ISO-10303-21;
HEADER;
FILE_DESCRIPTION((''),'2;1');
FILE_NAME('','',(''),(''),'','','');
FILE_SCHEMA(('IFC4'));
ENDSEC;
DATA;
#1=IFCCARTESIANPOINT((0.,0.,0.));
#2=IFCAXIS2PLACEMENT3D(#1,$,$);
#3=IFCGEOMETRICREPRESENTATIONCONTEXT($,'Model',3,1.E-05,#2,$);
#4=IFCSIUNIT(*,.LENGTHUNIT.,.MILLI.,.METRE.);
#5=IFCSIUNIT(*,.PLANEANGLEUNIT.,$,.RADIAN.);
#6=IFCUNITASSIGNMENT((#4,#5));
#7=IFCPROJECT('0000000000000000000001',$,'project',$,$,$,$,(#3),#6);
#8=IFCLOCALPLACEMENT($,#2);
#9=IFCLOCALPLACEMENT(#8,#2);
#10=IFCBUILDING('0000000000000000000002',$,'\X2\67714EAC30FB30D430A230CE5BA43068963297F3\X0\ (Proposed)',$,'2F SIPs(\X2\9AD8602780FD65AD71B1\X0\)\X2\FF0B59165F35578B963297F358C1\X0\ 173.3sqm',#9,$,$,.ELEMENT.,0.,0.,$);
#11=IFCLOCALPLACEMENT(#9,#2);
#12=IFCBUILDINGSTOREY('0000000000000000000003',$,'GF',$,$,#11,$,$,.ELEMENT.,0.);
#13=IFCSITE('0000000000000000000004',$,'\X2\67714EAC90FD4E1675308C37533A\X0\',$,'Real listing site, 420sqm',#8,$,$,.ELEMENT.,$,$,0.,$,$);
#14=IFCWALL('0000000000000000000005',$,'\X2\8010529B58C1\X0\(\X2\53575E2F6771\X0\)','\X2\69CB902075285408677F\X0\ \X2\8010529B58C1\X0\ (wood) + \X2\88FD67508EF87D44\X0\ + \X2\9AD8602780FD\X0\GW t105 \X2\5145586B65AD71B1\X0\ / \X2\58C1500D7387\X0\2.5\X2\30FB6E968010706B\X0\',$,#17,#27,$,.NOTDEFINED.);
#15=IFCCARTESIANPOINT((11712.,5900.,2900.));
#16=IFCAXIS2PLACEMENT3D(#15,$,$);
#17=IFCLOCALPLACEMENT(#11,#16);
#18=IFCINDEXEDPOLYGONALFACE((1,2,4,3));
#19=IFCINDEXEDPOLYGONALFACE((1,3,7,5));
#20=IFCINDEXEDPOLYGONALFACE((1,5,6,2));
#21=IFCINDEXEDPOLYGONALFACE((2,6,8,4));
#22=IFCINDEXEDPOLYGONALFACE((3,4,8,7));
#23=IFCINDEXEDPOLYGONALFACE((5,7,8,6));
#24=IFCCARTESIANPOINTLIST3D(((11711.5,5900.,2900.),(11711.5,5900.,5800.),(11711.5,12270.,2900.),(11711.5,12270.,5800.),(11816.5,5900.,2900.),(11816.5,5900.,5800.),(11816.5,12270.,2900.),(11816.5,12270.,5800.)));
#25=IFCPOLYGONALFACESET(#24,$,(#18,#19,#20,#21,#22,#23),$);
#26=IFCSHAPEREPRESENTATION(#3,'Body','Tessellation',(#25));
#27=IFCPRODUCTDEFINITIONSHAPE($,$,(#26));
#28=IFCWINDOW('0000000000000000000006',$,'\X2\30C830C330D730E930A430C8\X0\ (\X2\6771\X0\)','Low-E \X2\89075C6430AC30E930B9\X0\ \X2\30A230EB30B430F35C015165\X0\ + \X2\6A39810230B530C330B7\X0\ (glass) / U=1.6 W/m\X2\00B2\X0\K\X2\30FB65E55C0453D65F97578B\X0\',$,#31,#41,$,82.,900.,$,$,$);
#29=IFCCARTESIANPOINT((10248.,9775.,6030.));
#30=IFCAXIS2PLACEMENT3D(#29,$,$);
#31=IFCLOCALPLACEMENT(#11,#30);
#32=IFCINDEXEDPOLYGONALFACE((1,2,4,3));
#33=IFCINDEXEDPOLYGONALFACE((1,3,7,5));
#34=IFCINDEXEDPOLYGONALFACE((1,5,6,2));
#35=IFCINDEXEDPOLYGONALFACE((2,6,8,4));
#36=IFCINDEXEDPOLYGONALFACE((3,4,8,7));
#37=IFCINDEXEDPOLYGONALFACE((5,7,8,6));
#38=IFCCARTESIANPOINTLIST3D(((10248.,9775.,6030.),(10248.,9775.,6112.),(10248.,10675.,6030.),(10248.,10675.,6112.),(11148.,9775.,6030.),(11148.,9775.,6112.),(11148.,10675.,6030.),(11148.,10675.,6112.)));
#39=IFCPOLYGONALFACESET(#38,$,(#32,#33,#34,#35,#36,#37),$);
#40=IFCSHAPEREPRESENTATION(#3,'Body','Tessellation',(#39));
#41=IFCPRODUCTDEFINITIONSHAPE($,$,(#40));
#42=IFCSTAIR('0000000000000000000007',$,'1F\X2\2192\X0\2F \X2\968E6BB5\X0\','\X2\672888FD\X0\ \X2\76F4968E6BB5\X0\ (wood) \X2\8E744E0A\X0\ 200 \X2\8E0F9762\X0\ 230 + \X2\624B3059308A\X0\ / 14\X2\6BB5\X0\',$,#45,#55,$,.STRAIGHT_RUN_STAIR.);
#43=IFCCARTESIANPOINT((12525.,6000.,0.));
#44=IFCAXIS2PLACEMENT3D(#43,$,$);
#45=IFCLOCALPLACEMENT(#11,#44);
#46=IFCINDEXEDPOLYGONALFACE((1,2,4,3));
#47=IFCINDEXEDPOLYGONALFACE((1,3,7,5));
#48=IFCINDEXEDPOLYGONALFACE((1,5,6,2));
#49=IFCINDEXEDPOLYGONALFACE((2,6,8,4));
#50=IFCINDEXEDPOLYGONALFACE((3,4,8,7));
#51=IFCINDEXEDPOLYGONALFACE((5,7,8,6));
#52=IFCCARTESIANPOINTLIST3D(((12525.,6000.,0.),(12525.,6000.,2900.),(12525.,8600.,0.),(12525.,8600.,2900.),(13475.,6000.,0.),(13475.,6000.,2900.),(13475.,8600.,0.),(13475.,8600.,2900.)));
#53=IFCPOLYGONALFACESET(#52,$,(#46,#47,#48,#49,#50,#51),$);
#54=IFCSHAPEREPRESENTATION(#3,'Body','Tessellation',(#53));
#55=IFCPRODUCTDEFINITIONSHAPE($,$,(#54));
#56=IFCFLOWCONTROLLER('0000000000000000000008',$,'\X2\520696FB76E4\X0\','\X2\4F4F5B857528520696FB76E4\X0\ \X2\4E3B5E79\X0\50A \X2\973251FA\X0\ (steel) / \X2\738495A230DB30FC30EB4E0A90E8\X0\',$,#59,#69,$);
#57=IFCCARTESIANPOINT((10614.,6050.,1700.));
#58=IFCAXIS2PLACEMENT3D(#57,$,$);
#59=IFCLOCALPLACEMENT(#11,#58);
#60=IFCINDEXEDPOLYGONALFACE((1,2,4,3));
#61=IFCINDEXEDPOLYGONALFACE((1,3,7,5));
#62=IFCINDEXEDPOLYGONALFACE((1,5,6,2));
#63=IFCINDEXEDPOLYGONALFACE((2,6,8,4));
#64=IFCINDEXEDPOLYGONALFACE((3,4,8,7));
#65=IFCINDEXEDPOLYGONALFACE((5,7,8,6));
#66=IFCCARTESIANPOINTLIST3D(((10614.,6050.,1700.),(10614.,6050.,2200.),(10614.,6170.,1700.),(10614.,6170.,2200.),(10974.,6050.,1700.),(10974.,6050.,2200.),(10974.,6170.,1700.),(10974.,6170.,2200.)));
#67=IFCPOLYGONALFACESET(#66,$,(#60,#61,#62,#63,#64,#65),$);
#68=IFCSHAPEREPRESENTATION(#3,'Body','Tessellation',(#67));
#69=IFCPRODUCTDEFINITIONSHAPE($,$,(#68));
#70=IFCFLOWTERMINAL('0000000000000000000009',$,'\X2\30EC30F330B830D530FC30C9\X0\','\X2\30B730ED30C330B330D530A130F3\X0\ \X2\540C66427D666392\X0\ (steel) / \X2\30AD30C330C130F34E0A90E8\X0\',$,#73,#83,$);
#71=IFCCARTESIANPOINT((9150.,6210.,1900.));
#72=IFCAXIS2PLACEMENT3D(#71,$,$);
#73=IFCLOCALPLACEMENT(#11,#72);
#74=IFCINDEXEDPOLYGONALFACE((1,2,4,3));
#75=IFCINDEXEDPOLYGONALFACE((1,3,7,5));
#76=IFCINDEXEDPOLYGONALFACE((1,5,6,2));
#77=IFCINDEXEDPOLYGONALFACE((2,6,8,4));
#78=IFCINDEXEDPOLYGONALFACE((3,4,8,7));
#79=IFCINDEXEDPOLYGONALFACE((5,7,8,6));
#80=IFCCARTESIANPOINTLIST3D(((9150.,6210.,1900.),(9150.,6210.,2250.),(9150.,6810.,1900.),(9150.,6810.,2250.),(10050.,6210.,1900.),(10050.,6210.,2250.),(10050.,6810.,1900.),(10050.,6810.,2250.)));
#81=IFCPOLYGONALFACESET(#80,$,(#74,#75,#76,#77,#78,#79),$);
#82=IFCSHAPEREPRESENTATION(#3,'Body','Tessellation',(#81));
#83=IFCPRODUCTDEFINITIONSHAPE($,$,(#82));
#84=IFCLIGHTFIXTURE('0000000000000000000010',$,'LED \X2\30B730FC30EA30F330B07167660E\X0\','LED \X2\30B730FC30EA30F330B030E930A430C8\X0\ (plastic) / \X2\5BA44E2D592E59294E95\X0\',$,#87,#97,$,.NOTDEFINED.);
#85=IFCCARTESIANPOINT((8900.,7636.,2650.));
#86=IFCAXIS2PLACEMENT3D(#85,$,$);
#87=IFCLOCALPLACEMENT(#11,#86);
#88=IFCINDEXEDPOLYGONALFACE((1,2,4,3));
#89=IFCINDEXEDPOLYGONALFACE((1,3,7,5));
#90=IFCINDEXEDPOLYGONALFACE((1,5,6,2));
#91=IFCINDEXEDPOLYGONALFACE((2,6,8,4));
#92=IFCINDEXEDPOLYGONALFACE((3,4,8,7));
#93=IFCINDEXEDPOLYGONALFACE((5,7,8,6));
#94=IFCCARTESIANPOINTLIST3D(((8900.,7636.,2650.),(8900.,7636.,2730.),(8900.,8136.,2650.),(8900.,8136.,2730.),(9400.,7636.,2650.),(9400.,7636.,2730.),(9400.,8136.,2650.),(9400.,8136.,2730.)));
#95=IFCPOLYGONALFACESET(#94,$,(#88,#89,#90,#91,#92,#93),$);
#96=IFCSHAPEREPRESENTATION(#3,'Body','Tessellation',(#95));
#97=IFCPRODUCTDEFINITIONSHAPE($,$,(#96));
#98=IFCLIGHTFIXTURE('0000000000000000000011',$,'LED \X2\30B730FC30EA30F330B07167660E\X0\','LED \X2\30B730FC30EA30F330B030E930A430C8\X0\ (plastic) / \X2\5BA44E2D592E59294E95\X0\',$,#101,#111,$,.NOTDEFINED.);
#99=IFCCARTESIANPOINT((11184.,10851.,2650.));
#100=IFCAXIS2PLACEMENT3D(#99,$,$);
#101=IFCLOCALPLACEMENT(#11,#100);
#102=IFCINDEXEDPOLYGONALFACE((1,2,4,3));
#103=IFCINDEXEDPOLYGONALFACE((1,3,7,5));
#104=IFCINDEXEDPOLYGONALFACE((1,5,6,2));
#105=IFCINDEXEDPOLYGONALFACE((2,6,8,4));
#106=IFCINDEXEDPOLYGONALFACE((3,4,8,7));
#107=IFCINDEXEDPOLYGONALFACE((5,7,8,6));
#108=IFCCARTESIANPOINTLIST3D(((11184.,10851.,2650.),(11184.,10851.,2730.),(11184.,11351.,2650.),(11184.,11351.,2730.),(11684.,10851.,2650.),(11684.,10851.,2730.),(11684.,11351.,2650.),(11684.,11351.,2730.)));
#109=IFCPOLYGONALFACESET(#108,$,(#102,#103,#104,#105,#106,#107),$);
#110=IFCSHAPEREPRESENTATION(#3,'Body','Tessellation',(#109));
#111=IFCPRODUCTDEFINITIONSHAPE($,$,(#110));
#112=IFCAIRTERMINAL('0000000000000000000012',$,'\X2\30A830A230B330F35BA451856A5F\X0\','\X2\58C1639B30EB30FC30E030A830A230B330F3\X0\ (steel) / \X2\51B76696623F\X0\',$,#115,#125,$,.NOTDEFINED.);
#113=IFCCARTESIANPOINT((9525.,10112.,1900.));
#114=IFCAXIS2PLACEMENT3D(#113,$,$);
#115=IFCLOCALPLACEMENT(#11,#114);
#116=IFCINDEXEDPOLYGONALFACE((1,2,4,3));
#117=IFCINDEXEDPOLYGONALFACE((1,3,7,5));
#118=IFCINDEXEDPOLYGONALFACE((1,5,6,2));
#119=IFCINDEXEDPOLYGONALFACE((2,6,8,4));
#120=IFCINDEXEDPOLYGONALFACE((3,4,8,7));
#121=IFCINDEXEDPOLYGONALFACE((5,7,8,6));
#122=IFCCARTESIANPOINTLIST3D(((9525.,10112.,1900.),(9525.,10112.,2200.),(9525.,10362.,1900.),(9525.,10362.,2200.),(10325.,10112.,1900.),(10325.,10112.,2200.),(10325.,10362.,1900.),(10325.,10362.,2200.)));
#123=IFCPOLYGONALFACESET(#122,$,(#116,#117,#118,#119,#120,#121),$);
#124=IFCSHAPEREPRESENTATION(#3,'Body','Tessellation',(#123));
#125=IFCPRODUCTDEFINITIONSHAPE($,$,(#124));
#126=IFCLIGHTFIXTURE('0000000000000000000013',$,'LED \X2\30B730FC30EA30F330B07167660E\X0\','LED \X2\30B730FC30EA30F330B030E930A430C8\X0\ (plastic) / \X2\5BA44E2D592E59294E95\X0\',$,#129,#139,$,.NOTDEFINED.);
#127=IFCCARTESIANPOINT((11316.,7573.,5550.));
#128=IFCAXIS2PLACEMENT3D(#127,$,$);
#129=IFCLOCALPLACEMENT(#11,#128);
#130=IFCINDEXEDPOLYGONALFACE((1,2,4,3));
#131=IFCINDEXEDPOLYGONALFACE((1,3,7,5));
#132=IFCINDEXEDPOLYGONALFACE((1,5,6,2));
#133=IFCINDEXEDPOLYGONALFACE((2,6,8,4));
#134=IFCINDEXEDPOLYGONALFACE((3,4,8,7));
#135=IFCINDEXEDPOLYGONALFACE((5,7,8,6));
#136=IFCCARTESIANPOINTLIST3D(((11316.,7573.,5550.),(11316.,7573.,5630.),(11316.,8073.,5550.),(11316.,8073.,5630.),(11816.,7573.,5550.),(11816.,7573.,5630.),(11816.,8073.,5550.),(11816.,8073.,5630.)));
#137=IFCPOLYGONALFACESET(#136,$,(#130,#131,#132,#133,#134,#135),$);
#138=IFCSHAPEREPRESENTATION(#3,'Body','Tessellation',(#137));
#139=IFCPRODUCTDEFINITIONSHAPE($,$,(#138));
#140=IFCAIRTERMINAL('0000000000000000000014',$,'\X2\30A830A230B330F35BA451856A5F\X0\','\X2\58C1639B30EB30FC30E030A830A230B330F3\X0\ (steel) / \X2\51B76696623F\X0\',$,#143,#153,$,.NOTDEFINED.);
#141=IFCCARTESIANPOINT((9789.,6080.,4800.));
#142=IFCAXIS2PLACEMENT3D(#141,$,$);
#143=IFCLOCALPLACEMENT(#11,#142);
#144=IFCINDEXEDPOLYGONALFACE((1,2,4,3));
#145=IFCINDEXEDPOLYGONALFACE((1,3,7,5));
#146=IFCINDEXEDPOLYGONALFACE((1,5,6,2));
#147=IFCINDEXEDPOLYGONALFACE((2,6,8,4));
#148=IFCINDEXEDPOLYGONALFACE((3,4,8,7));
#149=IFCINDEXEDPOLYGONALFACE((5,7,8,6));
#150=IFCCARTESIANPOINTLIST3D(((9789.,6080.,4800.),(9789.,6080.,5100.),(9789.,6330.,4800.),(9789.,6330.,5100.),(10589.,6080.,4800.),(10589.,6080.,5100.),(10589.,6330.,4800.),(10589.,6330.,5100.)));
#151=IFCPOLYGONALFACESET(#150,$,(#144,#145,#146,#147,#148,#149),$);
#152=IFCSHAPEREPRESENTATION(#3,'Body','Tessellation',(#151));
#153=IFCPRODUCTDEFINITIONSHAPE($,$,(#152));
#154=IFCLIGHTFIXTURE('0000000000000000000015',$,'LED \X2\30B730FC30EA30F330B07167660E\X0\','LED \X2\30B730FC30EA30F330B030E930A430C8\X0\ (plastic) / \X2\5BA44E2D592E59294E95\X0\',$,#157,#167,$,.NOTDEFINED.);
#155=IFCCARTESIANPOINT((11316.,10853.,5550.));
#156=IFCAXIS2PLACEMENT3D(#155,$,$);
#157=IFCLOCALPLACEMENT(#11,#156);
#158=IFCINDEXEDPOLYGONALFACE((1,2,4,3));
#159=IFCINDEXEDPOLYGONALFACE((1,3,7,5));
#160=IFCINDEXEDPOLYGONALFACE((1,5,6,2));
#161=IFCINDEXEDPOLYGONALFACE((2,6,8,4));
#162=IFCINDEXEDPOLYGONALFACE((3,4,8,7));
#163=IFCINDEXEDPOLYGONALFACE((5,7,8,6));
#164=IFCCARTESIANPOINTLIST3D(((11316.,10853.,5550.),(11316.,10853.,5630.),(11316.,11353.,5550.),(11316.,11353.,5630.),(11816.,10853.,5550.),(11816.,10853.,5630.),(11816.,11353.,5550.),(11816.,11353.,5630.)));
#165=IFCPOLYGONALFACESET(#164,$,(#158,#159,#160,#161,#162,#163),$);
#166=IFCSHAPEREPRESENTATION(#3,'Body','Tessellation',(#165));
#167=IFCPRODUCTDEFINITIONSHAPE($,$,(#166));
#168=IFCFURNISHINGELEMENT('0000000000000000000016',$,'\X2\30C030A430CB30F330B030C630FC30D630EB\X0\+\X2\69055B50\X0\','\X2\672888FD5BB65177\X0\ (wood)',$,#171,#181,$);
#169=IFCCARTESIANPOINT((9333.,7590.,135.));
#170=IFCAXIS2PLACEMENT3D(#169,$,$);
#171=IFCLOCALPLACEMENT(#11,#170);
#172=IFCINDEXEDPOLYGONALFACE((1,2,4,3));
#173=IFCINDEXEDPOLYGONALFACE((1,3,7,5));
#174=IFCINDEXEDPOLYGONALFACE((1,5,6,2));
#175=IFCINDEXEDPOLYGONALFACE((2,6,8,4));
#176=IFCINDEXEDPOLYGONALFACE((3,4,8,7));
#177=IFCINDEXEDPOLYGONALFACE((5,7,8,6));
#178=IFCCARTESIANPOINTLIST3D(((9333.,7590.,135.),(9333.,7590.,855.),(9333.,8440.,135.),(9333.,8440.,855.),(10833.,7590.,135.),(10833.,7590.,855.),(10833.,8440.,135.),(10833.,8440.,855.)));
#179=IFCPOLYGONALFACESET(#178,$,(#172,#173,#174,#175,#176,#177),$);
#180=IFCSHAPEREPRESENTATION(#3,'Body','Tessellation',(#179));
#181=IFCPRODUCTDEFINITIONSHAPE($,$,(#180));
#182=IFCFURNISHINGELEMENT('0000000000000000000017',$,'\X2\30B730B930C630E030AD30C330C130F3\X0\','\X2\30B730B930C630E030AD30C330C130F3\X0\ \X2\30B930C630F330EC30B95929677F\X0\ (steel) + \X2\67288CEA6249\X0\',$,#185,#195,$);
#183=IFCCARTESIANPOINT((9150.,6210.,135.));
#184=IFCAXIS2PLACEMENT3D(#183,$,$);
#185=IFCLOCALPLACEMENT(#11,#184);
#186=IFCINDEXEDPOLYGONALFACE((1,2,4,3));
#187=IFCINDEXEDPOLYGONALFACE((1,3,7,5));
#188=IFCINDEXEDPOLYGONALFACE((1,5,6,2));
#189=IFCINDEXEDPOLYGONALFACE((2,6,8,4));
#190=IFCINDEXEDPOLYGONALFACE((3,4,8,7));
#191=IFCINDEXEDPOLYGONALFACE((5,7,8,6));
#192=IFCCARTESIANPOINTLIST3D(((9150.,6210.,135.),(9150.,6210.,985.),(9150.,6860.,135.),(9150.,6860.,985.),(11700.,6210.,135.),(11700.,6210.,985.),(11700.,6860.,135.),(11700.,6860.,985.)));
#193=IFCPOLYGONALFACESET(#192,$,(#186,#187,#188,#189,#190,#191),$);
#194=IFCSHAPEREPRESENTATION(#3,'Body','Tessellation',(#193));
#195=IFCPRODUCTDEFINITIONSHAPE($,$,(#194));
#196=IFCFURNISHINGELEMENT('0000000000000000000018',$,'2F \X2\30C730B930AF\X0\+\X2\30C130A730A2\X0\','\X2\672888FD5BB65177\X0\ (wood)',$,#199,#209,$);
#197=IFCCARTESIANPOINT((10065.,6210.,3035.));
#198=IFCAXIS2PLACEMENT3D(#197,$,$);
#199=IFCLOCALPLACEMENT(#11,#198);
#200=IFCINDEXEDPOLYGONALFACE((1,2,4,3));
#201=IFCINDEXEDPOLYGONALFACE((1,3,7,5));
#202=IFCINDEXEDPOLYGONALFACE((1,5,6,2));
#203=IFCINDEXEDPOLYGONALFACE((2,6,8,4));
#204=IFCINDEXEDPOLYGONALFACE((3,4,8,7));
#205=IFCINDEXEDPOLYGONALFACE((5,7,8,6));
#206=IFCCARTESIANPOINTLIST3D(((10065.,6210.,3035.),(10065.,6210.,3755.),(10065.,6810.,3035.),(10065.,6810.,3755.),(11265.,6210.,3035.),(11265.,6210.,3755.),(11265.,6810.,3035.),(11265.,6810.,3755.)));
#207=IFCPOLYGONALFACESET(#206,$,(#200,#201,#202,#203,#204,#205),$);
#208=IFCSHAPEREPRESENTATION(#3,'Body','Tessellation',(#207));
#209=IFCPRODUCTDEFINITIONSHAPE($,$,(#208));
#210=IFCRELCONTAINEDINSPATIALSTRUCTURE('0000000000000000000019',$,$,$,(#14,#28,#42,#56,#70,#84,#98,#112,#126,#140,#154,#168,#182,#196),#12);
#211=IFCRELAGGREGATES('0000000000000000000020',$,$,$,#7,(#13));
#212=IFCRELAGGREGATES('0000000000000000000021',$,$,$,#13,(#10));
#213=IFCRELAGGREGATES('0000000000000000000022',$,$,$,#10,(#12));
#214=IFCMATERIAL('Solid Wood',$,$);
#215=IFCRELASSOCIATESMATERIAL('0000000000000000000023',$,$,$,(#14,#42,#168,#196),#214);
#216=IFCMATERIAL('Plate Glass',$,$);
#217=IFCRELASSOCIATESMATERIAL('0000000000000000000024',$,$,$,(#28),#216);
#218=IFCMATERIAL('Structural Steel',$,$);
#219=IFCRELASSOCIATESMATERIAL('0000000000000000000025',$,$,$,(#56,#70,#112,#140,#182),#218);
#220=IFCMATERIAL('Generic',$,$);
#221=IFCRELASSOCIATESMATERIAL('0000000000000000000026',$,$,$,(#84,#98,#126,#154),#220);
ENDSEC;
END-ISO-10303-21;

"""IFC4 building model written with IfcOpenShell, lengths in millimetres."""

from ifc_helpers import new_model, si_unit, frame, frame_2d, origin, place, context, project, spatial, rectangle, extrude, material, element, save


model = new_model("IFC4")

# Units and contexts
model_context = context("Model", 3, precision=1e-05, world=origin())
ifc_project = project(units=[si_unit("LENGTHUNIT", "METRE", prefix="MILLI"), si_unit("PLANEANGLEUNIT", "RADIAN")], contexts=[model_context])

# Site, building, storey
site_placement = place(None, origin())
site = spatial("IfcSite", under=ifc_project, at=site_placement, Name="東京都世田谷区", ObjectType="Real listing site, 420sqm", CompositionType="ELEMENT", RefElevation=0.0)
building_placement = place(site_placement, origin())
building = spatial("IfcBuilding", under=site, at=building_placement, Name="東京・ピアノ室と防音 (Proposed)", ObjectType="2F SIPs(高性能断熱)＋外張型防音壁 173.3sqm", CompositionType="ELEMENT", ElevationOfRefHeight=0.0, ElevationOfTerrain=0.0)
storey_placement = place(building_placement, origin())
storey = spatial("IfcBuildingStorey", under=building, at=storey_placement, Name="GF", CompositionType="ELEMENT", Elevation=0.0)

# Shared definitions
ifc_material_1 = material(Name="Solid Wood")

# Wall
wall_1_placement = place(storey_placement, frame((11712.0, 5900.0, 2900.0)))
element("IfcWall", 1, at=wall_1_placement, inside=storey, material=ifc_material_1, Name="耐力壁(南帯東)", Description="構造用合板 耐力壁 (wood) + 製材軸組 + 高性能GW t105 充填断熱 / 壁倍率2.5・準耐火", PredefinedType="NOTDEFINED", context=model_context, shape_type="SweptSolid", body=[
    extrude(rectangle(XDim=105.0, YDim=6370.0, at=frame_2d((52.0, 3185.0))), frame((11712.0, 5900.0, 2900.0)), (0.0, 0.0, 1.0), 2900.0),
])

# Window
ifc_material_2 = material(Name="Plate Glass")
window_placement = place(storey_placement, frame((10248.0, 9775.0, 6030.0)))
element("IfcWindow", 2, at=window_placement, inside=storey, material=ifc_material_2, Name="トップライト (東)", Description="Low-E 複層ガラス アルゴン封入 + 樹脂サッシ (glass) / U=1.6 W/m²K・日射取得型", OverallHeight=82.0, OverallWidth=900.0, context=model_context, shape_type="SweptSolid", body=[
    extrude(rectangle(XDim=900.0, YDim=900.0, at=frame_2d((450.0, 450.0))), frame((10248.0, 9775.0, 6030.0)), (0.0, 0.0, 1.0), 82.0),
])

# Stair
stair_placement = place(storey_placement, frame((12525.0, 6000.0, 0.0)))
element("IfcStair", 3, at=stair_placement, inside=storey, material=ifc_material_1, Name="1F→2F 階段", Description="木製 直階段 (wood) 蹴上 200 踏面 230 + 手すり / 14段", PredefinedType="STRAIGHT_RUN_STAIR", context=model_context, shape_type="SweptSolid", body=[
    extrude(rectangle(XDim=950.0, YDim=2600.0, at=frame_2d((475.0, 1300.0))), frame((12525.0, 6000.0, 0.0)), (0.0, 0.0, 1.0), 2900.0),
])

# Flow controller
ifc_material_3 = material(Name="Structural Steel")
flow_controller_placement = place(storey_placement, frame((10614.0, 6050.0, 1700.0)))
element("IfcFlowController", 4, at=flow_controller_placement, inside=storey, material=ifc_material_3, Name="分電盤", Description="住宅用分電盤 主幹50A 露出 (steel) / 玄関ホール上部", context=model_context, shape_type="SweptSolid", body=[
    extrude(rectangle(XDim=360.0, YDim=120.0, at=frame_2d((180.0, 60.0))), frame((10614.0, 6050.0, 1700.0)), (0.0, 0.0, 1.0), 500.0),
])

# Flow terminal
flow_terminal_placement = place(storey_placement, frame((9150.0, 6210.0, 1900.0)))
element("IfcFlowTerminal", 5, at=flow_terminal_placement, inside=storey, material=ifc_material_3, Name="レンジフード", Description="シロッコファン 同時給排 (steel) / キッチン上部", context=model_context, shape_type="SweptSolid", body=[
    extrude(rectangle(XDim=900.0, YDim=600.0, at=frame_2d((450.0, 300.0))), frame((9150.0, 6210.0, 1900.0)), (0.0, 0.0, 1.0), 350.0),
])

# Light fixtures
ifc_material_4 = material(Name="Generic")
light_fixture_1_placement = place(storey_placement, frame((8900.0, 7636.0, 2650.0)))
element("IfcLightFixture", 6, at=light_fixture_1_placement, inside=storey, material=ifc_material_4, Name="LED シーリング照明", Description="LED シーリングライト (plastic) / 室中央天井", PredefinedType="NOTDEFINED", context=model_context, shape_type="SweptSolid", body=[
    extrude(rectangle(XDim=500.0, YDim=500.0, at=frame_2d((250.0, 250.0))), frame((8900.0, 7636.0, 2650.0)), (0.0, 0.0, 1.0), 80.0),
])
light_fixture_2_placement = place(storey_placement, frame((11184.0, 10851.0, 2650.0)))
element("IfcLightFixture", 7, at=light_fixture_2_placement, inside=storey, material=ifc_material_4, Name="LED シーリング照明", Description="LED シーリングライト (plastic) / 室中央天井", PredefinedType="NOTDEFINED", context=model_context, shape_type="SweptSolid", body=[
    extrude(rectangle(XDim=500.0, YDim=500.0, at=frame_2d((250.0, 250.0))), frame((11184.0, 10851.0, 2650.0)), (0.0, 0.0, 1.0), 80.0),
])

# Air terminal
air_terminal_1_placement = place(storey_placement, frame((9525.0, 10112.0, 1900.0)))
element("IfcAirTerminal", 8, at=air_terminal_1_placement, inside=storey, material=ifc_material_3, Name="エアコン室内機", Description="壁掛ルームエアコン (steel) / 冷暖房", PredefinedType="NOTDEFINED", context=model_context, shape_type="SweptSolid", body=[
    extrude(rectangle(XDim=800.0, YDim=250.0, at=frame_2d((400.0, 125.0))), frame((9525.0, 10112.0, 1900.0)), (0.0, 0.0, 1.0), 300.0),
])

# Light fixture
light_fixture_3_placement = place(storey_placement, frame((11316.0, 7573.0, 5550.0)))
element("IfcLightFixture", 9, at=light_fixture_3_placement, inside=storey, material=ifc_material_4, Name="LED シーリング照明", Description="LED シーリングライト (plastic) / 室中央天井", PredefinedType="NOTDEFINED", context=model_context, shape_type="SweptSolid", body=[
    extrude(rectangle(XDim=500.0, YDim=500.0, at=frame_2d((250.0, 250.0))), frame((11316.0, 7573.0, 5550.0)), (0.0, 0.0, 1.0), 80.0),
])

# Air terminal
air_terminal_2_placement = place(storey_placement, frame((9789.0, 6080.0, 4800.0)))
element("IfcAirTerminal", 10, at=air_terminal_2_placement, inside=storey, material=ifc_material_3, Name="エアコン室内機", Description="壁掛ルームエアコン (steel) / 冷暖房", PredefinedType="NOTDEFINED", context=model_context, shape_type="SweptSolid", body=[
    extrude(rectangle(XDim=800.0, YDim=250.0, at=frame_2d((400.0, 125.0))), frame((9789.0, 6080.0, 4800.0)), (0.0, 0.0, 1.0), 300.0),
])

# Light fixture
light_fixture_4_placement = place(storey_placement, frame((11316.0, 10853.0, 5550.0)))
element("IfcLightFixture", 11, at=light_fixture_4_placement, inside=storey, material=ifc_material_4, Name="LED シーリング照明", Description="LED シーリングライト (plastic) / 室中央天井", PredefinedType="NOTDEFINED", context=model_context, shape_type="SweptSolid", body=[
    extrude(rectangle(XDim=500.0, YDim=500.0, at=frame_2d((250.0, 250.0))), frame((11316.0, 10853.0, 5550.0)), (0.0, 0.0, 1.0), 80.0),
])

# Furnishing elements
furnishing_1_placement = place(storey_placement, frame((9333.0, 7590.0, 135.0)))
element("IfcFurnishingElement", 12, at=furnishing_1_placement, inside=storey, material=ifc_material_1, Name="ダイニングテーブル+椅子", Description="木製家具 (wood)", context=model_context, shape_type="SweptSolid", body=[
    extrude(rectangle(XDim=1500.0, YDim=850.0, at=frame_2d((750.0, 425.0))), frame((9333.0, 7590.0, 135.0)), (0.0, 0.0, 1.0), 720.0),
])
furnishing_2_placement = place(storey_placement, frame((9150.0, 6210.0, 135.0)))
element("IfcFurnishingElement", 13, at=furnishing_2_placement, inside=storey, material=ifc_material_3, Name="システムキッチン", Description="システムキッチン ステンレス天板 (steel) + 木質扉", context=model_context, shape_type="SweptSolid", body=[
    extrude(rectangle(XDim=2550.0, YDim=650.0, at=frame_2d((1275.0, 325.0))), frame((9150.0, 6210.0, 135.0)), (0.0, 0.0, 1.0), 850.0),
])
furnishing_3_placement = place(storey_placement, frame((10065.0, 6210.0, 3035.0)))
element("IfcFurnishingElement", 14, at=furnishing_3_placement, inside=storey, material=ifc_material_1, Name="2F デスク+チェア", Description="木製家具 (wood)", context=model_context, shape_type="SweptSolid", body=[
    extrude(rectangle(XDim=1200.0, YDim=600.0, at=frame_2d((600.0, 300.0))), frame((10065.0, 6210.0, 3035.0)), (0.0, 0.0, 1.0), 720.0),
])

save(model, "model.ifc")
